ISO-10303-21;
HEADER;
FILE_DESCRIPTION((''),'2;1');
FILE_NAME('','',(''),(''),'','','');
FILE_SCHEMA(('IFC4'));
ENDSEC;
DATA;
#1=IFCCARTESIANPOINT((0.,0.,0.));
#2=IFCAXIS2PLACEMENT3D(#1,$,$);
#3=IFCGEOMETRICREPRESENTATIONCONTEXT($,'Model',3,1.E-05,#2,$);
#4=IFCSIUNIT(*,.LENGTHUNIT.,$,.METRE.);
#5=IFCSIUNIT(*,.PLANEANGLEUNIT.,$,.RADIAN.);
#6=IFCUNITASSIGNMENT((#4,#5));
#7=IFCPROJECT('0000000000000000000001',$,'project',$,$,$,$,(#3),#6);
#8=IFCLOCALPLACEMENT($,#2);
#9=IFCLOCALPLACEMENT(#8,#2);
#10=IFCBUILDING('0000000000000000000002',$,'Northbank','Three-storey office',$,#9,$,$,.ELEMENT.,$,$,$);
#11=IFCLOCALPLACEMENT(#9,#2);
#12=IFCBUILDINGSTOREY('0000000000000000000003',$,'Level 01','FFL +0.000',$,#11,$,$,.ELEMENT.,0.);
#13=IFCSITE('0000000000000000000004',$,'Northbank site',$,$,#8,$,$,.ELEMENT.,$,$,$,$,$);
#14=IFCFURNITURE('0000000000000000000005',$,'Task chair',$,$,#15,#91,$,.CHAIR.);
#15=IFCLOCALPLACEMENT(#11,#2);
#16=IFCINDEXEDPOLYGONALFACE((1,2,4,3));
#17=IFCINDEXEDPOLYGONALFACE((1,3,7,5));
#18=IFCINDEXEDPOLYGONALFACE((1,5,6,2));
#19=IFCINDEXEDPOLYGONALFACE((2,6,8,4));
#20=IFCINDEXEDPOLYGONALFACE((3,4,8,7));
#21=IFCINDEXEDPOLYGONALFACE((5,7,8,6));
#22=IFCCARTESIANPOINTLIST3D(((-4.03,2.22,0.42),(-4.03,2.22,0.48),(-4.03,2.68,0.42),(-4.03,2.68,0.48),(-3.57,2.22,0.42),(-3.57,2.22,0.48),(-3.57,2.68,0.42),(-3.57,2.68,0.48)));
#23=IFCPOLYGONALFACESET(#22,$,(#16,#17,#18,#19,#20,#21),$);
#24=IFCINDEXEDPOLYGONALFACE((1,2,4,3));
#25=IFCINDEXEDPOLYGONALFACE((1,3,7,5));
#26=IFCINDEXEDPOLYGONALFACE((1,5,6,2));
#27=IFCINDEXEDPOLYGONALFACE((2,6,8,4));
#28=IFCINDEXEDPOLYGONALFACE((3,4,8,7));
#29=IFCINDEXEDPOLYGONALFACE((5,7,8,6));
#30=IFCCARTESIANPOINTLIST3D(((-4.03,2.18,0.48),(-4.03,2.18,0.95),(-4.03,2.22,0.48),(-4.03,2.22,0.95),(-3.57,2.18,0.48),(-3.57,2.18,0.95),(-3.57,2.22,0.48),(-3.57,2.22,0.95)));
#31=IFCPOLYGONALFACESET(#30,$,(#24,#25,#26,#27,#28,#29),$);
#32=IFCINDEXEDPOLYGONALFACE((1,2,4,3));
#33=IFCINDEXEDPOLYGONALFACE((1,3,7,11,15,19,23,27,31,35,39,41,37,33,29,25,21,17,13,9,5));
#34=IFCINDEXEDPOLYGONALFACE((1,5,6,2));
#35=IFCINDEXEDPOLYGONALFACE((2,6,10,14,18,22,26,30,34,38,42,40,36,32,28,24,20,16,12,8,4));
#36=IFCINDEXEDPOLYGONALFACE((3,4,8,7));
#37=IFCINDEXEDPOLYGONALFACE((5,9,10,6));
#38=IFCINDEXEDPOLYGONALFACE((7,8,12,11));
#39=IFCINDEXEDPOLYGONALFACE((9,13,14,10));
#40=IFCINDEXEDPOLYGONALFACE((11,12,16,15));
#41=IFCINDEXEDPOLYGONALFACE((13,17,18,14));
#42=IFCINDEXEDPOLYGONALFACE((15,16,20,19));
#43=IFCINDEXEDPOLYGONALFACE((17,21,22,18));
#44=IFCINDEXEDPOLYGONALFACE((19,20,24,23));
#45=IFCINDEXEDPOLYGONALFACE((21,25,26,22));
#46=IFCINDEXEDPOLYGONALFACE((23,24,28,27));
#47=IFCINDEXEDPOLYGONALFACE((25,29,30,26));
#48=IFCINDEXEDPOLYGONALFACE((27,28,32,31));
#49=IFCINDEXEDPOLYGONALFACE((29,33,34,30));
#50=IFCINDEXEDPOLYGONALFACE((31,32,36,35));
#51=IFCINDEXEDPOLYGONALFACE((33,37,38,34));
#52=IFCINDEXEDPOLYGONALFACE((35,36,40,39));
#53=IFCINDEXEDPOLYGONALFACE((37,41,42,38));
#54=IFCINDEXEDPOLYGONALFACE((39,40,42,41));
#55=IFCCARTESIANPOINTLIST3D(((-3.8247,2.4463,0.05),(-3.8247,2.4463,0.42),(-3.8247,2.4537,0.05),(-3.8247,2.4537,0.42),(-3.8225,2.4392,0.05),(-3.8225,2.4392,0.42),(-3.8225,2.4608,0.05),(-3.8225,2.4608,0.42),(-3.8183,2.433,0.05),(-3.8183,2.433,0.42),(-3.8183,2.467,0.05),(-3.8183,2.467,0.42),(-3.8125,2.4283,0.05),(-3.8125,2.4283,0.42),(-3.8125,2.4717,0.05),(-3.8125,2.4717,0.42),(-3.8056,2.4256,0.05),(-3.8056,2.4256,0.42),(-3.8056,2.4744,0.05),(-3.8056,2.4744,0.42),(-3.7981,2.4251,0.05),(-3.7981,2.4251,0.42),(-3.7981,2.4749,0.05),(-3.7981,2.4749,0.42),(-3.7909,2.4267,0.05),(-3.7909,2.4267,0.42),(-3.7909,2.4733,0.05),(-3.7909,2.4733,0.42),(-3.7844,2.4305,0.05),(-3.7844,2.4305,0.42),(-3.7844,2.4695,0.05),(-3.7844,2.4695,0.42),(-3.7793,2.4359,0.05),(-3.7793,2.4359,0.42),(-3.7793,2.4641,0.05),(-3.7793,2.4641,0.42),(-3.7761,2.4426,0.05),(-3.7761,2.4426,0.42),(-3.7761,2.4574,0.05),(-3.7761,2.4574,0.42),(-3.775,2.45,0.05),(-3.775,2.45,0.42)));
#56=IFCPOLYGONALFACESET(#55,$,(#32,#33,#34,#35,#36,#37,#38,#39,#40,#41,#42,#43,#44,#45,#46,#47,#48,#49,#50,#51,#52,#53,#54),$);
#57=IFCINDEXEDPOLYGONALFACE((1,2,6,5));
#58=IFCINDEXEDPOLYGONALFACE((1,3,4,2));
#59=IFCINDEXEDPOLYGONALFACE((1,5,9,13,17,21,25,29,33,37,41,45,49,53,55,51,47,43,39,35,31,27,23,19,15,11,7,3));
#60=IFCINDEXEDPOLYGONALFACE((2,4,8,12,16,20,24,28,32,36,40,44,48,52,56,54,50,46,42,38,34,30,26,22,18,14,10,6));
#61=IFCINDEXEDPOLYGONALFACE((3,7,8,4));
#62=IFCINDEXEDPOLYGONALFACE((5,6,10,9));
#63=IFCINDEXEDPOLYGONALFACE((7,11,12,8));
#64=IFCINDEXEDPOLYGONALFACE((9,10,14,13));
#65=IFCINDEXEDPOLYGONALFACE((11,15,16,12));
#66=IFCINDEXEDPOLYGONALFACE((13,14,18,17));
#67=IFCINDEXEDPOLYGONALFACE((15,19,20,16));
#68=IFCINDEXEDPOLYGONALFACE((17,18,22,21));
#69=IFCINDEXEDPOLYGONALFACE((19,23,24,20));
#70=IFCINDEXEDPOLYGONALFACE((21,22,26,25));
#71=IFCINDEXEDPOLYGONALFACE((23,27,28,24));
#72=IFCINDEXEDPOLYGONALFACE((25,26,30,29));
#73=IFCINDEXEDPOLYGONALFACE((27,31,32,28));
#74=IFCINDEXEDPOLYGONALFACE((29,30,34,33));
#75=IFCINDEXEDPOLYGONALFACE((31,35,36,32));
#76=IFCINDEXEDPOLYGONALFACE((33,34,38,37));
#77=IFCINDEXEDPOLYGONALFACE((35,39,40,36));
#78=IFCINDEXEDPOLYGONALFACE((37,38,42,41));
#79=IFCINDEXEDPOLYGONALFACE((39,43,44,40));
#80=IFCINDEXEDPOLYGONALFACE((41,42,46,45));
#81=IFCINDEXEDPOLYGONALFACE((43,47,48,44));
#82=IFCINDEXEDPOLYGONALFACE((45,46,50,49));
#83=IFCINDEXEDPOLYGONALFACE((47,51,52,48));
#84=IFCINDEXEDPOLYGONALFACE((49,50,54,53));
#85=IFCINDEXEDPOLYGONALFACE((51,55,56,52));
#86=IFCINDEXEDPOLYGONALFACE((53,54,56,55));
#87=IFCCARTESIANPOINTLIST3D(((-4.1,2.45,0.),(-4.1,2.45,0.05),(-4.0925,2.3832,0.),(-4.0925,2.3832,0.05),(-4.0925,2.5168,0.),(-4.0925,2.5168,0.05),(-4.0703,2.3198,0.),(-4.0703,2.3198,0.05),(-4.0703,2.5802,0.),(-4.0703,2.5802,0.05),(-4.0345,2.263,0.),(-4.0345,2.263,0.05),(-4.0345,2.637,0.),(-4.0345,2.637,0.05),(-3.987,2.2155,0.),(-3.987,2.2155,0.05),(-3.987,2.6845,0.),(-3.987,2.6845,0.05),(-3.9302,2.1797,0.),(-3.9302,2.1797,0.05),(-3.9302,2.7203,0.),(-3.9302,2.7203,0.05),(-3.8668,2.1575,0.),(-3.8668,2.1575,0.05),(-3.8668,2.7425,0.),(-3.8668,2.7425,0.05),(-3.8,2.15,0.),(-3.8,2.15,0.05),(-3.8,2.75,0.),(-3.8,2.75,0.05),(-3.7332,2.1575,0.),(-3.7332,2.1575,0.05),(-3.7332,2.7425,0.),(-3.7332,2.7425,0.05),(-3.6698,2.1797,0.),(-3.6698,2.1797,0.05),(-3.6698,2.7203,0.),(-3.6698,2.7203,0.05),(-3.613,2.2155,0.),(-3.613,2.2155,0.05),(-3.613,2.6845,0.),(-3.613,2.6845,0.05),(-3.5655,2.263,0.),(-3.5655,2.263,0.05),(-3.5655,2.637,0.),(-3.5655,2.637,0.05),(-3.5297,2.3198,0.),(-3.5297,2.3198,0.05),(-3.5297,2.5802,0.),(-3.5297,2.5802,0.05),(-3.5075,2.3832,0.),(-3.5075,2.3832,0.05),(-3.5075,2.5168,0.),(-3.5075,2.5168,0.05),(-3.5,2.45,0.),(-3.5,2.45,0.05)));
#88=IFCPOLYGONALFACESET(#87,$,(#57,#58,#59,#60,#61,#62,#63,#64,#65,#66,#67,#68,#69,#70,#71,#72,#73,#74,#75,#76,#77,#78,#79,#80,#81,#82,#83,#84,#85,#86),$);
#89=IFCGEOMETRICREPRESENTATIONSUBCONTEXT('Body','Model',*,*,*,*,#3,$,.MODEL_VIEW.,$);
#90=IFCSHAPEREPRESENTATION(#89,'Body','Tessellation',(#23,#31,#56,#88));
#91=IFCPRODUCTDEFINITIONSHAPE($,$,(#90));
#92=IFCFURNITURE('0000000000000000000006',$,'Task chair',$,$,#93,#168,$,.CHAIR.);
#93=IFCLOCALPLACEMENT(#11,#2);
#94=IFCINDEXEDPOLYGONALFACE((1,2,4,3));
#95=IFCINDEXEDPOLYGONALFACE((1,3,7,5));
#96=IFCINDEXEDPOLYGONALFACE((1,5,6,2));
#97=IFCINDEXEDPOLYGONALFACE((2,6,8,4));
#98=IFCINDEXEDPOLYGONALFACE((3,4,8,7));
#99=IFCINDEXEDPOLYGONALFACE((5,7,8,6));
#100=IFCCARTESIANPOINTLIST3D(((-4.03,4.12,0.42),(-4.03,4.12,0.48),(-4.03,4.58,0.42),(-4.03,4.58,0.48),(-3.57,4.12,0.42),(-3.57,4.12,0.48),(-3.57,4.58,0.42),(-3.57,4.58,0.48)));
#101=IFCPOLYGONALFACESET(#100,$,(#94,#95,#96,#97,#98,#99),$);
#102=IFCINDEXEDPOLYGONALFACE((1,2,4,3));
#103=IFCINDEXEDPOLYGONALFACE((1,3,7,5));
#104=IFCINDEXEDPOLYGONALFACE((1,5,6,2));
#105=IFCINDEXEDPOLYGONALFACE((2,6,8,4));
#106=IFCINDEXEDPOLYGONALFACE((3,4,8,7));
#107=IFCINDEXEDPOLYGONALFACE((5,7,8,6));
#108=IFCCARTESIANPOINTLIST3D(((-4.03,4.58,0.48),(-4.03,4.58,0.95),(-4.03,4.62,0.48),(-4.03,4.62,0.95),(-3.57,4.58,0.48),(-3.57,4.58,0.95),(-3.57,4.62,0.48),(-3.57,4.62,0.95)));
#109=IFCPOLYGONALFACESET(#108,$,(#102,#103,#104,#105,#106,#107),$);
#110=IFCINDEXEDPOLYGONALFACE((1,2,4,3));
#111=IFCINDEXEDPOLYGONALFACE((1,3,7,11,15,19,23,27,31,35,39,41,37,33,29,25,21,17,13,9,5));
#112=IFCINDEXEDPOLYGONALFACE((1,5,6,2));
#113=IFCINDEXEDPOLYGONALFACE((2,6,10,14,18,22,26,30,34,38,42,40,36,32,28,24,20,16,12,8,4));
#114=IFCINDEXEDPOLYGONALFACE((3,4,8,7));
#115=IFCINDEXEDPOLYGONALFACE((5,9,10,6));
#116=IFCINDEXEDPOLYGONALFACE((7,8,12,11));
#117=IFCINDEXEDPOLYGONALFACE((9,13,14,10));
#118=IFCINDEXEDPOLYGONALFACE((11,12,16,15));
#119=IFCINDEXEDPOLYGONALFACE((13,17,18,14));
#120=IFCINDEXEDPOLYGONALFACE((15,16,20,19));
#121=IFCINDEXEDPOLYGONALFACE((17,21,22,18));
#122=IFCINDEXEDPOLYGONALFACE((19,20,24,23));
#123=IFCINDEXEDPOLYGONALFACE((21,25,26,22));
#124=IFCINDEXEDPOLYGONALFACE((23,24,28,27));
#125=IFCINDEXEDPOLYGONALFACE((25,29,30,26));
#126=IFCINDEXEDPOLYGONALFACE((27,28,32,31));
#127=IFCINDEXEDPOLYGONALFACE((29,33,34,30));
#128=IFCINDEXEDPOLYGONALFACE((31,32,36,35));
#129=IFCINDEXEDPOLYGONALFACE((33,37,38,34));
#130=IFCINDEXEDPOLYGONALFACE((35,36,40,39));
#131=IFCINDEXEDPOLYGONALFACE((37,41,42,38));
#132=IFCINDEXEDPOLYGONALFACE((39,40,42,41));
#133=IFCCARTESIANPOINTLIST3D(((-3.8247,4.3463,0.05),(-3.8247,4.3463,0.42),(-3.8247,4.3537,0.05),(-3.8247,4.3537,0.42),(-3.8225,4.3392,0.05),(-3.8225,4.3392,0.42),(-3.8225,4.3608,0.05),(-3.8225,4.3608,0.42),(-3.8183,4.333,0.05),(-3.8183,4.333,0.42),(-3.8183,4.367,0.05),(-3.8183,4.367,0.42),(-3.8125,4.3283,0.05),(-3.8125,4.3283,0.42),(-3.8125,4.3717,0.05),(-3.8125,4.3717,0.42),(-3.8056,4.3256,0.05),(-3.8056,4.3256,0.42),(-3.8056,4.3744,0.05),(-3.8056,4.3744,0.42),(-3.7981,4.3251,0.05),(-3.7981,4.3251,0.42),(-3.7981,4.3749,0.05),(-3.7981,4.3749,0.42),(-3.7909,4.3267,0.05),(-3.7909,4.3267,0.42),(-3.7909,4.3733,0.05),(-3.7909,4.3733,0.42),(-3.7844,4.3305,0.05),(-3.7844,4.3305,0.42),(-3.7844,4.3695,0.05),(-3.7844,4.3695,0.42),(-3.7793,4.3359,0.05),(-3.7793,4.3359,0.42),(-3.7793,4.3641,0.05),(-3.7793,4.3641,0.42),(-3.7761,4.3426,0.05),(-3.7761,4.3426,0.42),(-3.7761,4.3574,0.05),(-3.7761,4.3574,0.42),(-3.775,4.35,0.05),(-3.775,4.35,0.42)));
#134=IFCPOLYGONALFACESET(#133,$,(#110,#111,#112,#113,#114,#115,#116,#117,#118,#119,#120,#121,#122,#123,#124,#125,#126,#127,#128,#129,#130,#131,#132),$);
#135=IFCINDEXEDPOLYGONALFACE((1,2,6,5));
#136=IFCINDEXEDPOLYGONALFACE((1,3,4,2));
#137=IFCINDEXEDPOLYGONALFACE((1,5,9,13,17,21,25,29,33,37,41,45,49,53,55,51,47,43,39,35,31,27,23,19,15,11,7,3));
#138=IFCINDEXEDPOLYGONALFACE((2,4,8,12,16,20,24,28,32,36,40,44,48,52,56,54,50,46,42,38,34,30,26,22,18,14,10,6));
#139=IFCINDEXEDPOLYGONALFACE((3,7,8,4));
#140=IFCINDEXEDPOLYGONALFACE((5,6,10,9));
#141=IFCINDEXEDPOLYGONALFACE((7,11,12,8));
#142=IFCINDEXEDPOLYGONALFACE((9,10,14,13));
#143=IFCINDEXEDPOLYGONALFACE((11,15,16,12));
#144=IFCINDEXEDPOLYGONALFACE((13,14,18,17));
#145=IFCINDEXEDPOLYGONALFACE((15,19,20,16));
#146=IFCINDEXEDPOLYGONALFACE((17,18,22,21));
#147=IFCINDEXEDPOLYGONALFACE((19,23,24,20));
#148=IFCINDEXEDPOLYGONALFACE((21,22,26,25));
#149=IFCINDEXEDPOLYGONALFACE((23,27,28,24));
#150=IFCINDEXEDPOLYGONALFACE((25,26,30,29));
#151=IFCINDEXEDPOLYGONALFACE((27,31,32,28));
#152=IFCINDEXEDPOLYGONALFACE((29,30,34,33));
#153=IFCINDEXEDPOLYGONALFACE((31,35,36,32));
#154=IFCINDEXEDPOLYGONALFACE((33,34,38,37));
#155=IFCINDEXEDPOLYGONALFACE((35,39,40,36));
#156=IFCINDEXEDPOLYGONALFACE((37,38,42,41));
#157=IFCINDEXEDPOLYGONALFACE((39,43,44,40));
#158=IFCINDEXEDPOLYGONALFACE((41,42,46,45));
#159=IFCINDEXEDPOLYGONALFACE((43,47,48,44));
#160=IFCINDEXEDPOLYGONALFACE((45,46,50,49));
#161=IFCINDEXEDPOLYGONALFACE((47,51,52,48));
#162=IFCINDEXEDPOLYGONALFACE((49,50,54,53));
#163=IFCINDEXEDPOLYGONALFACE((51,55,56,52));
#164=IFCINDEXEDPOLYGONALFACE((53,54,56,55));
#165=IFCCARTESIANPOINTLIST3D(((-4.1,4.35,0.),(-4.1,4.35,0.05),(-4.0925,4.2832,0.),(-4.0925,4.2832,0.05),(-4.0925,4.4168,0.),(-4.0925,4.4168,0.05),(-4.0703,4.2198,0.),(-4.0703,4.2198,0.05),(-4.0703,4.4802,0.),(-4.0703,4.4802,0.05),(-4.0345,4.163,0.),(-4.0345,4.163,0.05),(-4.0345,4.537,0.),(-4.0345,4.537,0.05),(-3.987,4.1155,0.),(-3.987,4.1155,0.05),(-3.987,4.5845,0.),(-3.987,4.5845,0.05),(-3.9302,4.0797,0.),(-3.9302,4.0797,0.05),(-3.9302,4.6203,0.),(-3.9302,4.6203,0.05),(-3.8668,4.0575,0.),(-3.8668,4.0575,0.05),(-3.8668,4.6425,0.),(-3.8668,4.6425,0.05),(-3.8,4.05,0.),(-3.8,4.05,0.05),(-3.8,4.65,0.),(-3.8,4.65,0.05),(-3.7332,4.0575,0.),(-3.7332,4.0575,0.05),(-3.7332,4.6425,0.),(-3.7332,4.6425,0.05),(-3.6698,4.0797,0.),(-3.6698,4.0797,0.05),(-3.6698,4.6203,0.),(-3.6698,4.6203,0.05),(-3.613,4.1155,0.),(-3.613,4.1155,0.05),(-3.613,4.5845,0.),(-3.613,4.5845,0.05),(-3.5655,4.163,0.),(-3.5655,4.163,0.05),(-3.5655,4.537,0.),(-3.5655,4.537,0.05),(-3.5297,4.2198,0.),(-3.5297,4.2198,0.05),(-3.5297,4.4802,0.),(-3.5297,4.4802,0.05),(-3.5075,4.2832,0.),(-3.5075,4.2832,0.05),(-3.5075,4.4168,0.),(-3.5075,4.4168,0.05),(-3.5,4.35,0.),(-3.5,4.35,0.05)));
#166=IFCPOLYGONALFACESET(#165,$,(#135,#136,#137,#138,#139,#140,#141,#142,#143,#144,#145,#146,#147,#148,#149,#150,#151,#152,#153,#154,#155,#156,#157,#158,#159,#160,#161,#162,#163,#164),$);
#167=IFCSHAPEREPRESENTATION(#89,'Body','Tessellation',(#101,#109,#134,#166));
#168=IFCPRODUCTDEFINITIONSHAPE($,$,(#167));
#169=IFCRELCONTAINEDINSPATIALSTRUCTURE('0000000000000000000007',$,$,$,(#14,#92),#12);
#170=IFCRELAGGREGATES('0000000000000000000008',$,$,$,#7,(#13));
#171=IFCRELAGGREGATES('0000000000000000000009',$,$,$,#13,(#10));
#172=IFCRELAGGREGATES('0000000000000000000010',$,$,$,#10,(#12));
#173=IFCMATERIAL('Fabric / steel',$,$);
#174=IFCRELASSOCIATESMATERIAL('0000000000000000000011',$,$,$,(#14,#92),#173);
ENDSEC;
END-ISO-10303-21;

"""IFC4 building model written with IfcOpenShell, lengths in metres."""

from ifc_helpers import new_model, si_unit, frame, origin, place, context, subcontext, project, spatial, rectangle, circle, extrude, material, element, save


model = new_model("IFC4")

# Units and contexts
model_context = context("Model", 3, precision=1e-05, world=origin())
body_context = subcontext(model_context, "Body", "Model", "MODEL_VIEW")
ifc_project = project(units=[si_unit("LENGTHUNIT", "METRE"), si_unit("PLANEANGLEUNIT", "RADIAN")], contexts=[model_context])

# Site, building, storey
site_placement = place(None, origin())
site = spatial("IfcSite", under=ifc_project, at=site_placement, Name="Northbank site", CompositionType="ELEMENT")
building_placement = place(site_placement, origin())
building = spatial("IfcBuilding", under=site, at=building_placement, Name="Northbank", Description="Three-storey office", CompositionType="ELEMENT")
storey_placement = place(building_placement, origin())
storey = spatial("IfcBuildingStorey", under=building, at=storey_placement, Name="Level 01", Description="FFL +0.000", CompositionType="ELEMENT", Elevation=0.0)

# Furniture
ifc_material_1 = material(Name="Fabric / steel")
furniture_1_placement = place(storey_placement, origin())
element("IfcFurniture", 1, at=furniture_1_placement, inside=storey, material=ifc_material_1, Name="Task chair", PredefinedType="CHAIR", context=body_context, shape_type="SweptSolid", body=[
    extrude(rectangle(XDim=0.46, YDim=0.46), frame((-3.8, 2.45, 0.42)), (0.0, 0.0, 1.0), 0.06),
    extrude(rectangle(XDim=0.46, YDim=0.04), frame((-3.8, 2.2, 0.48)), (0.0, 0.0, 1.0), 0.47),
    extrude(circle(Radius=0.025), frame((-3.8, 2.45, 0.05), z_axis=(0.0, 0.0, 1.0), x_axis=(1.0, 0.0, 0.0)), (0.0, 0.0, 1.0), 0.37),
    extrude(circle(Radius=0.3), frame((-3.8, 2.45, 0.0), z_axis=(0.0, 0.0, 1.0), x_axis=(1.0, 0.0, 0.0)), (0.0, 0.0, 1.0), 0.05),
])
furniture_2_placement = place(storey_placement, origin())
element("IfcFurniture", 2, at=furniture_2_placement, inside=storey, material=ifc_material_1, Name="Task chair", PredefinedType="CHAIR", context=body_context, shape_type="SweptSolid", body=[
    extrude(rectangle(XDim=0.46, YDim=0.46), frame((-3.8, 4.35, 0.42)), (0.0, 0.0, 1.0), 0.06),
    extrude(rectangle(XDim=0.46, YDim=0.04), frame((-3.8, 4.6, 0.48)), (0.0, 0.0, 1.0), 0.47),
    extrude(circle(Radius=0.025), frame((-3.8, 4.35, 0.05), z_axis=(0.0, 0.0, 1.0), x_axis=(1.0, 0.0, 0.0)), (0.0, 0.0, 1.0), 0.37),
    extrude(circle(Radius=0.3), frame((-3.8, 4.35, 0.0), z_axis=(0.0, 0.0, 1.0), x_axis=(1.0, 0.0, 0.0)), (0.0, 0.0, 1.0), 0.05),
])

save(model, "model.ifc")
